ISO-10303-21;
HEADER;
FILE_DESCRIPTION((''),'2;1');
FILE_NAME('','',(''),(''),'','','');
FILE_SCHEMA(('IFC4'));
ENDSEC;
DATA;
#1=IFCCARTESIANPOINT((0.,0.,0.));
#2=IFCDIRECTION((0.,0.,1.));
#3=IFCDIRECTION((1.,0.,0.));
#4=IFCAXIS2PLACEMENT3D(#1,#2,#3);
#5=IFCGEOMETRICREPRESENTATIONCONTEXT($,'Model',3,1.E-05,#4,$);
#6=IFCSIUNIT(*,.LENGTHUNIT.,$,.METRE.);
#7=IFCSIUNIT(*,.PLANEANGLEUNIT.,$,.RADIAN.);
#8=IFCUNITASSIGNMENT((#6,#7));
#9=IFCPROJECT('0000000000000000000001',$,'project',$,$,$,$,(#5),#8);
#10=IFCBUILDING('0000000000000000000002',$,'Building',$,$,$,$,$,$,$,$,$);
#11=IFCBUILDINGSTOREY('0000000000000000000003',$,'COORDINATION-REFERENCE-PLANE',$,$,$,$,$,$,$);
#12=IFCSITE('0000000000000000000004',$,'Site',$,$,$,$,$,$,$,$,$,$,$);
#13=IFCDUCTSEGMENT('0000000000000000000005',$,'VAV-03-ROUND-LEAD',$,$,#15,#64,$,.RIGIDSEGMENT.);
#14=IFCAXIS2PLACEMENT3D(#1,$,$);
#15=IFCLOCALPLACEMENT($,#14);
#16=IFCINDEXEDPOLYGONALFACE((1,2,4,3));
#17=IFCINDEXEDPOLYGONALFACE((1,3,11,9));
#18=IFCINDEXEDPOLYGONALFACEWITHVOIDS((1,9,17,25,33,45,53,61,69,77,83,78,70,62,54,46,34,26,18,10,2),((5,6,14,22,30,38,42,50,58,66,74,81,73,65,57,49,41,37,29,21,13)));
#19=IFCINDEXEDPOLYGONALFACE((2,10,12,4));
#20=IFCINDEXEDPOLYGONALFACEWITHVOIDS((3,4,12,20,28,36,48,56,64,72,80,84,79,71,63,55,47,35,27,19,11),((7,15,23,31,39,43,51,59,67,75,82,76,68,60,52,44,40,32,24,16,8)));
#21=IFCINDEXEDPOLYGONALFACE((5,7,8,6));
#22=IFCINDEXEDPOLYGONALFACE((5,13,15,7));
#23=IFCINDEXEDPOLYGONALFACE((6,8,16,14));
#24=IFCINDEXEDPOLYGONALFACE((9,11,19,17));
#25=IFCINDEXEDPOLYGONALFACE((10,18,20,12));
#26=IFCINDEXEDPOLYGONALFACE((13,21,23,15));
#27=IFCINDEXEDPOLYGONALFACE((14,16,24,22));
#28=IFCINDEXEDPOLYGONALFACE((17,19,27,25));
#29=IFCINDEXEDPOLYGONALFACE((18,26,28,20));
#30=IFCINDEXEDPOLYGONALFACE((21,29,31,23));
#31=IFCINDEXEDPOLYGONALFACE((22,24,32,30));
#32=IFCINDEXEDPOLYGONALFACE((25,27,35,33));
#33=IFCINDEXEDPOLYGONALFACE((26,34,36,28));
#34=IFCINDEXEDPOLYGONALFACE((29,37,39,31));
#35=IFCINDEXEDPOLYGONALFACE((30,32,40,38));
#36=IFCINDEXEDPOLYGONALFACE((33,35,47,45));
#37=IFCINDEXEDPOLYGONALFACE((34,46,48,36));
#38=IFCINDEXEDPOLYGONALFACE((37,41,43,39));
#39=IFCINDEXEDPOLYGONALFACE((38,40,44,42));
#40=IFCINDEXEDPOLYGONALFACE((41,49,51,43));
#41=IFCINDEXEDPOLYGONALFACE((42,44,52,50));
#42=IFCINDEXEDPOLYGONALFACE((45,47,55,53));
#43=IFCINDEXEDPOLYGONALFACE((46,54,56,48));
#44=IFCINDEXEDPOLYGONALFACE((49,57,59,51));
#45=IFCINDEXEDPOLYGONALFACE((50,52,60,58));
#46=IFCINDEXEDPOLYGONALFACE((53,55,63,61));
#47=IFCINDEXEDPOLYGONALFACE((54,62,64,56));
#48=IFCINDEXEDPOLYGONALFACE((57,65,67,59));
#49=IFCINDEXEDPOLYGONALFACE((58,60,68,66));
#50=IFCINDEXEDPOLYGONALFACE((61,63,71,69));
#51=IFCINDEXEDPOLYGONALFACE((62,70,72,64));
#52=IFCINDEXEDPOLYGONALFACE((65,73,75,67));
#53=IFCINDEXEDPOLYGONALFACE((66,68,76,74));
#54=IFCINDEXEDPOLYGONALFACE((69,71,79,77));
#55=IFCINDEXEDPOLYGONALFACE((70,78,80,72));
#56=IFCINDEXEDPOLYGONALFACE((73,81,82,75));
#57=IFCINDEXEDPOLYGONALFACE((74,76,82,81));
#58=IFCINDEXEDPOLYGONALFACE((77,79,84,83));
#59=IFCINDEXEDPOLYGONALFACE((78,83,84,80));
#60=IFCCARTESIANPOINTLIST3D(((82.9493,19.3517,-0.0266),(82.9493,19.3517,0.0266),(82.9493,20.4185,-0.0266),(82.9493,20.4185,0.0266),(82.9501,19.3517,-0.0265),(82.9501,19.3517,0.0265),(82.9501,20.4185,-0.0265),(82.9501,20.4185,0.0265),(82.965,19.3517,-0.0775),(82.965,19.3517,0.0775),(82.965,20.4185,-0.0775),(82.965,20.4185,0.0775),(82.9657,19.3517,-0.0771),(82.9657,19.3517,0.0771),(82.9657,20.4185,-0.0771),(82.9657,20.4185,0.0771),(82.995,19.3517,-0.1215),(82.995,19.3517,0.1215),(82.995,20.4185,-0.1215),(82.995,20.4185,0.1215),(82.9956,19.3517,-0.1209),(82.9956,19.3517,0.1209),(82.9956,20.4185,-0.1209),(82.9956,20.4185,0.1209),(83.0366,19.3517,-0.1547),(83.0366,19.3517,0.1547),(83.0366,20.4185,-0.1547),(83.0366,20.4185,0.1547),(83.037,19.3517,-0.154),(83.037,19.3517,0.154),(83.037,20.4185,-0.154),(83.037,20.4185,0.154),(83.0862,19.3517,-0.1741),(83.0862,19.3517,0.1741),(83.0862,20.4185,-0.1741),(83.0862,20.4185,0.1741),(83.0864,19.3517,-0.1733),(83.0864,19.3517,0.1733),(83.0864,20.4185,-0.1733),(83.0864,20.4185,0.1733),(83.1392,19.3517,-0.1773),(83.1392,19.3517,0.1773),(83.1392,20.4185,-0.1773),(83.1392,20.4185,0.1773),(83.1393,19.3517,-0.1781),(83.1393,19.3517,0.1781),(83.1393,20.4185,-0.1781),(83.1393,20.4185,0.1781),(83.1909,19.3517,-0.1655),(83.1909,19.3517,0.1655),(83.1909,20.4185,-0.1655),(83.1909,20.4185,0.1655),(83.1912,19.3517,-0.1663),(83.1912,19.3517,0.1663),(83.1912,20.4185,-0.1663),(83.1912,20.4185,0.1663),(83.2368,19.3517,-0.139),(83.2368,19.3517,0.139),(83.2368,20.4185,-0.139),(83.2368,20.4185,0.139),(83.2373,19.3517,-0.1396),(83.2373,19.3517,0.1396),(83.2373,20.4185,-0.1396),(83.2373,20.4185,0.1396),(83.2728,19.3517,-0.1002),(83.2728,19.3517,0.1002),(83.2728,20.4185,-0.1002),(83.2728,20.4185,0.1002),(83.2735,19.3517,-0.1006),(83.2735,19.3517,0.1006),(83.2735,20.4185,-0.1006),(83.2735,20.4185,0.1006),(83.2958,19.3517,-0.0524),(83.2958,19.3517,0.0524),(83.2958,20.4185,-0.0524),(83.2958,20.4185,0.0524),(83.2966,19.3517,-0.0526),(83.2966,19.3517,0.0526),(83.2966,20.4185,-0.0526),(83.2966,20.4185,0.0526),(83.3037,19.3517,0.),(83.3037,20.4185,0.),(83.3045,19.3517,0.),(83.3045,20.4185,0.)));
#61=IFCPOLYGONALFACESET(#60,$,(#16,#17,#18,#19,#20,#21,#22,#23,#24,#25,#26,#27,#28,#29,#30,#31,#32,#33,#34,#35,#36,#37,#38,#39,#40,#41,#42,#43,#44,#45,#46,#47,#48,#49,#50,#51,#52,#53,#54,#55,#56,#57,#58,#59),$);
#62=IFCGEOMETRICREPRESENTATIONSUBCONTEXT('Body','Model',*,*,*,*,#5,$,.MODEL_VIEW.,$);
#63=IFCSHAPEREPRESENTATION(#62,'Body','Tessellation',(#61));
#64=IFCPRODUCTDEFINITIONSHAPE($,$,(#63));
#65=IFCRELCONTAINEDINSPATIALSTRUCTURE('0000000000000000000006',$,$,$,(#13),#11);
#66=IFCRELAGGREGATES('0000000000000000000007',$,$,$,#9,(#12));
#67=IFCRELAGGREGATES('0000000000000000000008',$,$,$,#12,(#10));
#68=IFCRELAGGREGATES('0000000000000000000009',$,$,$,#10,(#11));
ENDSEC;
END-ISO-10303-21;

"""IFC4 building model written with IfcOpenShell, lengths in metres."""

from ifc_helpers import new_model, si_unit, frame, origin, origin_with_axes, place, context, subcontext, project, spatial, hollow_circle, extrude, element, save


model = new_model("IFC4")

# Units and contexts
model_context_1 = context("Model", 3, precision=1e-05, world=origin_with_axes())
body_context_1 = subcontext(model_context_1, "Body", "Model", "MODEL_VIEW")
ifc_project = project(units=[si_unit("LENGTHUNIT", "METRE"), si_unit("PLANEANGLEUNIT", "RADIAN")], contexts=[model_context_1])

# Site, building, storey
site = spatial("IfcSite", under=ifc_project, Name="Site")
building = spatial("IfcBuilding", under=site, Name="Building")
storey = spatial("IfcBuildingStorey", under=building, Name="COORDINATION-REFERENCE-PLANE")

# Duct segment
duct_segment_1_placement = place(None, frame((83.1259, 20.4185, 0.0), z_axis=(0.0, -1.0, 0.0), x_axis=(1.0, 0.0, 0.0)))
element("IfcDuctSegment", 1, at=duct_segment_1_placement, inside=storey, Name="VAV-03-ROUND-LEAD", PredefinedType="RIGIDSEGMENT", context=body_context_1, shape_type="SweptSolid", body=[
    extrude(hollow_circle(Radius=0.1786, WallThickness=0.0008), origin(), (0.0, 0.0, 1.0), 1.0668),
])

save(model, "model.ifc")
